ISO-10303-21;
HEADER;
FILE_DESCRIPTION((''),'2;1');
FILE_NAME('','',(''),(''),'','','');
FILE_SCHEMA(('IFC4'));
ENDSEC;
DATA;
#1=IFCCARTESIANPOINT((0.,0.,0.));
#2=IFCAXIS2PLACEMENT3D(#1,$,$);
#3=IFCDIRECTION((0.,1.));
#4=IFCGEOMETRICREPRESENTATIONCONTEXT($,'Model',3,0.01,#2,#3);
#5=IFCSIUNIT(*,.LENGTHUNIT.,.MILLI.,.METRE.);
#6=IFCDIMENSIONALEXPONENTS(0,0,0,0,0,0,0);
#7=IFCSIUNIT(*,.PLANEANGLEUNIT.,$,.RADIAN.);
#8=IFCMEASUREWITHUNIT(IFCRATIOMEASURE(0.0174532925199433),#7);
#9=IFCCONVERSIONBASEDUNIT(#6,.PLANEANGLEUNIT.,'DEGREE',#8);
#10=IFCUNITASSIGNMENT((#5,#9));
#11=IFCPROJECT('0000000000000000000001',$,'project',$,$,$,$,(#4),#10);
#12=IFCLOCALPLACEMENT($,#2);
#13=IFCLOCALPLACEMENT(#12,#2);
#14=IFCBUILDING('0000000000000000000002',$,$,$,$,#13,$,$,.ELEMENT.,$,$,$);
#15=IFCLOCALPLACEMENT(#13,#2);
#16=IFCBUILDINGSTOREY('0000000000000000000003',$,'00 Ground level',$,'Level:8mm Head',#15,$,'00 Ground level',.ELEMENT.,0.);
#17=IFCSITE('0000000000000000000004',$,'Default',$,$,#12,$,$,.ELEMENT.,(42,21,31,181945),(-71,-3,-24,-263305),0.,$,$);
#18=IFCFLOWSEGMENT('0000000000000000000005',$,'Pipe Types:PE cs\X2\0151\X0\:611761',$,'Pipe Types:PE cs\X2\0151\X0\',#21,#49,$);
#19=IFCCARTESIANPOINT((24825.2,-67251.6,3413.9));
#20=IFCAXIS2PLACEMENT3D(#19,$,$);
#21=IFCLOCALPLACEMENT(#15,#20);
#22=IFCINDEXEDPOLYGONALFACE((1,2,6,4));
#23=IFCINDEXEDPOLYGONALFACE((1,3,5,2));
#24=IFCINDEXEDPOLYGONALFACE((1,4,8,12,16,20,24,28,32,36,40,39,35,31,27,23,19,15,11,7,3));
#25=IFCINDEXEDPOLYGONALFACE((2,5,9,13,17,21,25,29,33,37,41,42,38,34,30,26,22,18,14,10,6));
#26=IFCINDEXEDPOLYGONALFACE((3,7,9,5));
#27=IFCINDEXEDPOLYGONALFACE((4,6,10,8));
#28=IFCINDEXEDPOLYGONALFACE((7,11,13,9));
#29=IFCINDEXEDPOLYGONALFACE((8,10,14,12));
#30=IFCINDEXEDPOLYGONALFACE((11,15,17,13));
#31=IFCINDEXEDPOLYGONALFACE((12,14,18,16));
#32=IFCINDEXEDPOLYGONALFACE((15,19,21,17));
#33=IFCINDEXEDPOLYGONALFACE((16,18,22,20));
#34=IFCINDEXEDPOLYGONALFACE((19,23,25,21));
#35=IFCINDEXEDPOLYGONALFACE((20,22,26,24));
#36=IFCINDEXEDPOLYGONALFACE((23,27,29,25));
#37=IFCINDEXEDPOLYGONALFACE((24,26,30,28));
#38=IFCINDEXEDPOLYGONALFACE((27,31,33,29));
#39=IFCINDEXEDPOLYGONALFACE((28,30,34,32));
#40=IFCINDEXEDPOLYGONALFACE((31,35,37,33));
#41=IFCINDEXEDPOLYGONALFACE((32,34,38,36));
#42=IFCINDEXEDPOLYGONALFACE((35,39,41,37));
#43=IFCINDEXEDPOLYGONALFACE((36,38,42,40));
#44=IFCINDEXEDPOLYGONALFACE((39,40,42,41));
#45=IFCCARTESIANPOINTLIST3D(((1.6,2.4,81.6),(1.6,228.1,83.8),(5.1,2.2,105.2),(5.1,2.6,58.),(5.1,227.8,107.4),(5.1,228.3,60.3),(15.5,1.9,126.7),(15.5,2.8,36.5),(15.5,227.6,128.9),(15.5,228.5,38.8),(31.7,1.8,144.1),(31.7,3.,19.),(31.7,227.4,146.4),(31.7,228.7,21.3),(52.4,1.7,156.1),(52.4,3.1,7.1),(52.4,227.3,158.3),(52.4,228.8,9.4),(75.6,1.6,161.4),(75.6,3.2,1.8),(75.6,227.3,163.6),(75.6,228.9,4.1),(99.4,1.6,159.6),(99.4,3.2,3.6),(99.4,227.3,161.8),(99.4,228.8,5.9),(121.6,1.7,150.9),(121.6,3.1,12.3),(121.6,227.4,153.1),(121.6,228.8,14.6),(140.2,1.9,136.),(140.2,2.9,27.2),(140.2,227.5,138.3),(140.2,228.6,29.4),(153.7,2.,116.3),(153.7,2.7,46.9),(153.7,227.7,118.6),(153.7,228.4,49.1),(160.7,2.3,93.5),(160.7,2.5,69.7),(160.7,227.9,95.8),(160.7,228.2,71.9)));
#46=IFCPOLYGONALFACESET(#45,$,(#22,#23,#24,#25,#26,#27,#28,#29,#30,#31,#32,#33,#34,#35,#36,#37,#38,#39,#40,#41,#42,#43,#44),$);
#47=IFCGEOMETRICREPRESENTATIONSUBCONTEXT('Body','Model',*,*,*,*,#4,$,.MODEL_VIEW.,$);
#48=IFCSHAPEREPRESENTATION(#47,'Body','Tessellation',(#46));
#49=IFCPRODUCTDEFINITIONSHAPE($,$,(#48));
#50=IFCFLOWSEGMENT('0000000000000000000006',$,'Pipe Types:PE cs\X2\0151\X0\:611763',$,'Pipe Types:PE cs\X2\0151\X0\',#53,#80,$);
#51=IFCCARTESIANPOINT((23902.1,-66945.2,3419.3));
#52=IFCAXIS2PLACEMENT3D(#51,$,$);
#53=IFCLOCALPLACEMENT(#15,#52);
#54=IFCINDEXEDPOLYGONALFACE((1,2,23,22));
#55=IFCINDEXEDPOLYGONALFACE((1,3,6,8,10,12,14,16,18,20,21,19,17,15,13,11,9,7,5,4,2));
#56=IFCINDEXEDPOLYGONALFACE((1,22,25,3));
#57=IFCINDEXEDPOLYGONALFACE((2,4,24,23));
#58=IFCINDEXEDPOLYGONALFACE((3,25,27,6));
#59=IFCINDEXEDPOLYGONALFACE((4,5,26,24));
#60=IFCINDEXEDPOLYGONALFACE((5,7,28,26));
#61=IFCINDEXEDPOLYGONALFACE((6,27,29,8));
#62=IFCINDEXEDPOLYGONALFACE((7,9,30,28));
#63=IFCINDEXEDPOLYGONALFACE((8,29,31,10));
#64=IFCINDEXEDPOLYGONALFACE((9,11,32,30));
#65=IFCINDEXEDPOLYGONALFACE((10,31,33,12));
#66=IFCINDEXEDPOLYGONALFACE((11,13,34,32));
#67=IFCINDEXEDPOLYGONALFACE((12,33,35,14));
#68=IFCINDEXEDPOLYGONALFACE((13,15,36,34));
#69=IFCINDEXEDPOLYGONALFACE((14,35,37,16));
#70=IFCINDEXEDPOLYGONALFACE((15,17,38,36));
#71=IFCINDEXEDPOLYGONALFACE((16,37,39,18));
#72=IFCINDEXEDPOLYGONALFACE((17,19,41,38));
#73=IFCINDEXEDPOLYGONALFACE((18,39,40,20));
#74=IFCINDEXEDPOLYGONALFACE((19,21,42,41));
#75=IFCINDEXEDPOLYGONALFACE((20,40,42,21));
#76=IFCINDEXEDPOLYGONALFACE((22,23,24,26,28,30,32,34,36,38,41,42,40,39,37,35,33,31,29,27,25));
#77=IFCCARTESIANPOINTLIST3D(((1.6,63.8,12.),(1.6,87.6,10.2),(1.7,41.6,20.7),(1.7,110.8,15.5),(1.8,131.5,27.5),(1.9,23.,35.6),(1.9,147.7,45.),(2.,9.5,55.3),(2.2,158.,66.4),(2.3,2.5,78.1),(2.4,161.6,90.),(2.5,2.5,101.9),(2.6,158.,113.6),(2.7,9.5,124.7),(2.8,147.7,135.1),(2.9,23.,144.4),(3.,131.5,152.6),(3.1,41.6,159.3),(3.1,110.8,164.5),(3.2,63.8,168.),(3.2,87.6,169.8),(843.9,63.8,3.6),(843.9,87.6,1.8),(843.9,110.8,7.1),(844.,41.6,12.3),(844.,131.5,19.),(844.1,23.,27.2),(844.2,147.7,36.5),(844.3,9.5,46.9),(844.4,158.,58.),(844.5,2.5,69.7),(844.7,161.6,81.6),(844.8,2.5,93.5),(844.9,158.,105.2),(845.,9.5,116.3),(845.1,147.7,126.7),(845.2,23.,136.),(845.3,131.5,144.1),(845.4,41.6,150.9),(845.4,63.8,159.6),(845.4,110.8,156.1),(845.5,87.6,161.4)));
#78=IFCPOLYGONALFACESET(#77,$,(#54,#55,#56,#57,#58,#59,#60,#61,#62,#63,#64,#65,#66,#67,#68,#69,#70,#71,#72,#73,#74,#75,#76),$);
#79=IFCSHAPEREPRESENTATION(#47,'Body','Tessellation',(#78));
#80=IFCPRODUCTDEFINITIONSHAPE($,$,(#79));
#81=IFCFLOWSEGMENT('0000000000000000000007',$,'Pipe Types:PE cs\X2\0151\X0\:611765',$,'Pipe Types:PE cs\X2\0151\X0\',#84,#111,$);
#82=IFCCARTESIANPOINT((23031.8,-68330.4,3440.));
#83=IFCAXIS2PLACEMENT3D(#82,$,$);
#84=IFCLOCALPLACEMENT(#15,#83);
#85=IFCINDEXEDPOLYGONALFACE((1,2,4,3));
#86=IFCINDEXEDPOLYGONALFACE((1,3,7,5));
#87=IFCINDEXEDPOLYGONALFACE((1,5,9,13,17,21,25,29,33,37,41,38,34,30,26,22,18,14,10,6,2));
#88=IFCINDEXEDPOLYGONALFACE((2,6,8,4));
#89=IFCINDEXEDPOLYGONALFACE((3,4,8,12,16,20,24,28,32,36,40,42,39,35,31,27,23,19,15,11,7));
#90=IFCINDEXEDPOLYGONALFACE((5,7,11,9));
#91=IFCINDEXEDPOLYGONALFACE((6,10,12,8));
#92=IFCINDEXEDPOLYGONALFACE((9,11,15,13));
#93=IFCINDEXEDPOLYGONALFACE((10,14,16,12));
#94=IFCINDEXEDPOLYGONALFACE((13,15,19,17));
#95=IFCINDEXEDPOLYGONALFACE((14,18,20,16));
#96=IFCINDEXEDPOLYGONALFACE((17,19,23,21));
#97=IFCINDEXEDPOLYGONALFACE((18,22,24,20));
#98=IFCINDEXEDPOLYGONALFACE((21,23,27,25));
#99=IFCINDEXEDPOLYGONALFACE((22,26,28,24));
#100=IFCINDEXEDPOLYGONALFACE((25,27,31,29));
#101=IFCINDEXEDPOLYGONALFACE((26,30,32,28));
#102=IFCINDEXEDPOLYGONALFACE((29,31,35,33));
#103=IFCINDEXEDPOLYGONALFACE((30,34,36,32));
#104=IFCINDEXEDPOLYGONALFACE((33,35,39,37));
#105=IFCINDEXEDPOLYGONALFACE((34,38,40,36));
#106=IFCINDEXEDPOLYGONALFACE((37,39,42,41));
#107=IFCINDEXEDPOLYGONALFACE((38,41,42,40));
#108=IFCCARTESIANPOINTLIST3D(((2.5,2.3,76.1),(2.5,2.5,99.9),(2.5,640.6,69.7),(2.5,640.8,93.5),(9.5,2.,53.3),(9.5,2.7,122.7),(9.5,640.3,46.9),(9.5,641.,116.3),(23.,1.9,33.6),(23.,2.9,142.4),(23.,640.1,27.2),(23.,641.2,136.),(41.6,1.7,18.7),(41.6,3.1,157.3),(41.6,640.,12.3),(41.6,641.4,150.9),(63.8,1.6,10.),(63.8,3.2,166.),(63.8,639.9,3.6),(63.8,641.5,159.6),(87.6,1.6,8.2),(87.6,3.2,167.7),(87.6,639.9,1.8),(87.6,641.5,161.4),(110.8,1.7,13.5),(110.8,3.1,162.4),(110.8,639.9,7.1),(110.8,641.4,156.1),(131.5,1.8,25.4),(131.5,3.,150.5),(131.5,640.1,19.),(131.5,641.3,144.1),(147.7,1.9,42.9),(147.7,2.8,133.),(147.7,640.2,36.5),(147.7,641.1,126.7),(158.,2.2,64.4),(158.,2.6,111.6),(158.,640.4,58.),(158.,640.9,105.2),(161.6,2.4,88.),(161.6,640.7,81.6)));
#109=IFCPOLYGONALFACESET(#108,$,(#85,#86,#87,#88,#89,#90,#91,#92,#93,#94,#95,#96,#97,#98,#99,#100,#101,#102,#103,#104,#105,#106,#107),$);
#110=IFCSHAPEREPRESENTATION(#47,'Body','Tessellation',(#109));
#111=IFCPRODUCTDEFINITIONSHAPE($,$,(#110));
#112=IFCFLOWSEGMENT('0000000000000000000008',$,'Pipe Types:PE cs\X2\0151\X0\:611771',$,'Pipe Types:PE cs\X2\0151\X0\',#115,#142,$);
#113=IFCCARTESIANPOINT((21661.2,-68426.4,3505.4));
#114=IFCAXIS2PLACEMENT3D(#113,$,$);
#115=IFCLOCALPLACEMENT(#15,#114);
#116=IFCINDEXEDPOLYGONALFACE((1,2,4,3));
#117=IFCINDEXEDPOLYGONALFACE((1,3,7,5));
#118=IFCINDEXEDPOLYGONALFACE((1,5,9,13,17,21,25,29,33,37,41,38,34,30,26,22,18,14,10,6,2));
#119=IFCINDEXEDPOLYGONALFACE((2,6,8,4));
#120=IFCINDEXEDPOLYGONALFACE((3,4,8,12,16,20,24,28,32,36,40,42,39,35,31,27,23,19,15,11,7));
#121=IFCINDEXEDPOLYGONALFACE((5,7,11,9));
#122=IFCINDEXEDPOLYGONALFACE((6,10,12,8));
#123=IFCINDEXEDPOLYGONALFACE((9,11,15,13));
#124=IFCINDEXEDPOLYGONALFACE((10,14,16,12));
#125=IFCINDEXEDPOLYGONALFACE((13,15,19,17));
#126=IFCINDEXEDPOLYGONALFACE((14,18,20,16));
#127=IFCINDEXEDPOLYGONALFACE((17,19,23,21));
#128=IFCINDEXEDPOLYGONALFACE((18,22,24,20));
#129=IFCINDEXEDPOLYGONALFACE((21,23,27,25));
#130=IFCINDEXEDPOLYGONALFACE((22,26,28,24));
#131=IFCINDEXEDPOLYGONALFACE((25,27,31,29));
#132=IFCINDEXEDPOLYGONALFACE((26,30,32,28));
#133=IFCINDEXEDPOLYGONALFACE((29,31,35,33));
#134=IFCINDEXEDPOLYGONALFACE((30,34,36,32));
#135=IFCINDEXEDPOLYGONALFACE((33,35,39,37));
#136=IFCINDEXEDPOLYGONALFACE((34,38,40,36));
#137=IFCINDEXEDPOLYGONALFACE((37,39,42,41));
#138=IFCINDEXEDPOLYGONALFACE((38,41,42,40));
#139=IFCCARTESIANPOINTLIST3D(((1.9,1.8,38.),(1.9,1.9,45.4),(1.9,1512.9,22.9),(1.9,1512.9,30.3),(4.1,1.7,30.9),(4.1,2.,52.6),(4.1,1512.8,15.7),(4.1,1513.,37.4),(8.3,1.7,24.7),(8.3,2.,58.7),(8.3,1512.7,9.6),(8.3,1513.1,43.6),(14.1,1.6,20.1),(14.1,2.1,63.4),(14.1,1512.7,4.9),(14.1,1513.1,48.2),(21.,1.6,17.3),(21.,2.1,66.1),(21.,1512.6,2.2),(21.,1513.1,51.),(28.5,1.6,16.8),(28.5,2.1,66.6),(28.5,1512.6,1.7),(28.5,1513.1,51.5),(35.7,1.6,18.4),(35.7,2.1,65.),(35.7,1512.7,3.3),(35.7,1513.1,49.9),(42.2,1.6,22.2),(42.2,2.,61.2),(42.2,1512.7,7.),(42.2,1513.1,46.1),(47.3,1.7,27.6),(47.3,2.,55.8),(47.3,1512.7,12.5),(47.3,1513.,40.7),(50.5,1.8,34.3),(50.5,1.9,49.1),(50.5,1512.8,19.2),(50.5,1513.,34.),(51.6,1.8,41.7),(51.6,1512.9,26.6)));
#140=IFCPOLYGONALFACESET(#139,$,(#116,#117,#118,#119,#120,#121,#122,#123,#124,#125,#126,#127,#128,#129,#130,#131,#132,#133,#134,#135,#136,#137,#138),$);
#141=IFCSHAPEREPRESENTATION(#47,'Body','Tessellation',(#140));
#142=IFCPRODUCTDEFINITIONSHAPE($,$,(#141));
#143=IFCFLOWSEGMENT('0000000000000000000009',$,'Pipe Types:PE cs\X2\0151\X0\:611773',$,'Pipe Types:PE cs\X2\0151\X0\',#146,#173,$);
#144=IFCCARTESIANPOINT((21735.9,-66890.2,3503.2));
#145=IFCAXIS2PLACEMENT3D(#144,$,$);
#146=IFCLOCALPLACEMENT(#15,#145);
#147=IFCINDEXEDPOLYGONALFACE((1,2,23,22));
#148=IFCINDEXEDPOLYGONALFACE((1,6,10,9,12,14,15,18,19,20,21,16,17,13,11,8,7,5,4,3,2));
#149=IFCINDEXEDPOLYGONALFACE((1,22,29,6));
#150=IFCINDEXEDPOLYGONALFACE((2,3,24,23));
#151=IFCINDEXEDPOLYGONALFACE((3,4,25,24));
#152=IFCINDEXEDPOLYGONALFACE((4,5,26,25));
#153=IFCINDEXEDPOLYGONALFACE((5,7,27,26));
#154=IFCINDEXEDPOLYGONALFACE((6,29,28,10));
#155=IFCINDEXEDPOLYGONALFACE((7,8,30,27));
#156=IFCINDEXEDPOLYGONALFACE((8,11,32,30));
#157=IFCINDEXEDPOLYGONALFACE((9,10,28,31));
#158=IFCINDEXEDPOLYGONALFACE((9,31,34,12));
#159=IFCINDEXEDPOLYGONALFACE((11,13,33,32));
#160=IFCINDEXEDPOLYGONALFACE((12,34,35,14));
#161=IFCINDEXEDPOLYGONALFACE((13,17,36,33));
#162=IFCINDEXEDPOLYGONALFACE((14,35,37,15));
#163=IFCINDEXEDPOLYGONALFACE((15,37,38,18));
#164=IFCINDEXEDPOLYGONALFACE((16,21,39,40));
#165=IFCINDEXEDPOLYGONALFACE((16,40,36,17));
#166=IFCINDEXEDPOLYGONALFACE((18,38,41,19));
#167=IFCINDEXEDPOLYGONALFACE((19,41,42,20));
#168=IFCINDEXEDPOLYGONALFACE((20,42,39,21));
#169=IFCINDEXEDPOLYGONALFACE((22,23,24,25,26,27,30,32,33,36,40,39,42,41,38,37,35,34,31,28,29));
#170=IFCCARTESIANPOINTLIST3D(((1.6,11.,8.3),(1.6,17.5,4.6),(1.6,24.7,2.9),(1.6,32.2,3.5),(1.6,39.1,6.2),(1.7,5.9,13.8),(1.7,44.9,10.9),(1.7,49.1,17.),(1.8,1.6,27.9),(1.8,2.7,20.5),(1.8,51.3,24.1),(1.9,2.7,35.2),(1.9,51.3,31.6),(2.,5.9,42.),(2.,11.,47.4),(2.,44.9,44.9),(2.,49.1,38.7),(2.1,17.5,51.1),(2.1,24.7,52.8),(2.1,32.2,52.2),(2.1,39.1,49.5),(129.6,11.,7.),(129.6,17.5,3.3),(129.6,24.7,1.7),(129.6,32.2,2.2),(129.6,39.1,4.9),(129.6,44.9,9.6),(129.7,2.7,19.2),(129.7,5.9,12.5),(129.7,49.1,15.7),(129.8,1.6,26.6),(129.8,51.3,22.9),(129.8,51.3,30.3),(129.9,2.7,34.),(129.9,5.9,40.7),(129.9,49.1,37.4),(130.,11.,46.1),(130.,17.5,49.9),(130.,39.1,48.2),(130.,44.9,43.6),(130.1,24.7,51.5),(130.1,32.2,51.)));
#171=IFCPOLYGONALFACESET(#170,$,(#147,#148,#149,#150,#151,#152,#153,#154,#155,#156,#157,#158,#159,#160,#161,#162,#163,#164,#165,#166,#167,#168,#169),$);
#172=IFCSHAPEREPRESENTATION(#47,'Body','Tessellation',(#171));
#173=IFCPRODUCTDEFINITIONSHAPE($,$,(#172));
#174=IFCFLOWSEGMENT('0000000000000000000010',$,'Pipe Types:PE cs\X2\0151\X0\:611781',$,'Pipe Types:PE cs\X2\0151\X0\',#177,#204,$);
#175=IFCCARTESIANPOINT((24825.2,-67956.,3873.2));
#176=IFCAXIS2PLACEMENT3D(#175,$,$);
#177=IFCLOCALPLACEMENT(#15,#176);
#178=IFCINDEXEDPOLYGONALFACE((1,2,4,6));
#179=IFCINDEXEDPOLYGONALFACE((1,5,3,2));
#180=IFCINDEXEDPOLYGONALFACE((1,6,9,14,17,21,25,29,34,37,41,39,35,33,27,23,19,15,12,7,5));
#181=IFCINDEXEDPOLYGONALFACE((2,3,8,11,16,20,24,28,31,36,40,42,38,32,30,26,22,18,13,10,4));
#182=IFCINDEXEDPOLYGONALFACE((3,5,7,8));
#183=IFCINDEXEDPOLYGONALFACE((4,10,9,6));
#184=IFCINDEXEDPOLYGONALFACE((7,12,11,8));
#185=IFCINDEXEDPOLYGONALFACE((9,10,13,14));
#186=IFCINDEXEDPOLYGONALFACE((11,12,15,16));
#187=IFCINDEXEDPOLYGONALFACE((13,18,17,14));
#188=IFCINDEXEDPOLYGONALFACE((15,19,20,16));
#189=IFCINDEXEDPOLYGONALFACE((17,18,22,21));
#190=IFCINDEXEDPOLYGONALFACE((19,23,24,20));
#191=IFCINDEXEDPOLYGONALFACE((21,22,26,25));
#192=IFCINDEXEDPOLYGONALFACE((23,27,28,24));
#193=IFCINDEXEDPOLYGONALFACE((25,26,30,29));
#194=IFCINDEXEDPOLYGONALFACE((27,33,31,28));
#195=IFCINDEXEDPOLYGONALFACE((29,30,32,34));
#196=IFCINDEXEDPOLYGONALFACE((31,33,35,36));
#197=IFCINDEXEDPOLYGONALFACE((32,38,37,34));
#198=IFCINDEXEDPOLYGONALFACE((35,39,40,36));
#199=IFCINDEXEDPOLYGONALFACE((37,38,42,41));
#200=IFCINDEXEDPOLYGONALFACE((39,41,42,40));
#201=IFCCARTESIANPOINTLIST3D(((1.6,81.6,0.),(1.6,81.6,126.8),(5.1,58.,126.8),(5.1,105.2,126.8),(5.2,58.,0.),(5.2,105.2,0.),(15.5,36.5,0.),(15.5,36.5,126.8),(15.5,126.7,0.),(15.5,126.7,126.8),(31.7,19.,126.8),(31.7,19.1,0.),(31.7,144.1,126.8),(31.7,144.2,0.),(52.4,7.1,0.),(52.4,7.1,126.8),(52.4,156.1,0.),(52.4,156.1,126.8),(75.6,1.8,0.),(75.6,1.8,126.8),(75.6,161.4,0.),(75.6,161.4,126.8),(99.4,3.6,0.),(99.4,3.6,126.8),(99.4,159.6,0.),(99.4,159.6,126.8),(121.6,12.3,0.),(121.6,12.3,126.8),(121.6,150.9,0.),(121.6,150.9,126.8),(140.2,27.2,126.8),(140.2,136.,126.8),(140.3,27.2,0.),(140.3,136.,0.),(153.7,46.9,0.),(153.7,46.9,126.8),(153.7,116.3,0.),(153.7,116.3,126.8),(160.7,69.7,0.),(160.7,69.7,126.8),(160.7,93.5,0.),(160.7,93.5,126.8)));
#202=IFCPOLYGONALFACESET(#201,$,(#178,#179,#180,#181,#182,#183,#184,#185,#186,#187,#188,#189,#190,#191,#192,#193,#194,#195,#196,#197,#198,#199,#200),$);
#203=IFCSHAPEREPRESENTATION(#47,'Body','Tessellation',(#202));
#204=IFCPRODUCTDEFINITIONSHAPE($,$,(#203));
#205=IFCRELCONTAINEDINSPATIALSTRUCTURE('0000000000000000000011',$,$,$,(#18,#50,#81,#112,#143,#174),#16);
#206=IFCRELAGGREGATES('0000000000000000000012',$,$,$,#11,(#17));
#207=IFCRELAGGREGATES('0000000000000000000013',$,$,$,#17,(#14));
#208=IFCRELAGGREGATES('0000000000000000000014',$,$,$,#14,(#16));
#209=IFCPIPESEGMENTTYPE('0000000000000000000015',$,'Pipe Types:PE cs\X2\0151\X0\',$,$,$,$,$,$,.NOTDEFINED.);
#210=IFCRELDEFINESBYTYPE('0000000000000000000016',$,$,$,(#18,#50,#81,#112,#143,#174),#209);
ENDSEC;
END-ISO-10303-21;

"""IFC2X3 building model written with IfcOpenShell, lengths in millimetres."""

from ifc_helpers import new_model, entity, si_unit, converted_unit, direction, frame, frame_2d, origin, origin_2d_with_axis, place, context, subcontext, project, spatial, circle, extrude, type_object, element, save


model = new_model("IFC2X3")

# Units and contexts
model_context = context("Model", 3, precision=0.01, world=origin(), true_north=direction((0.0, 1.0)))
body_context = subcontext(model_context, "Body", "Model", "MODEL_VIEW")
ifc_project = project(units=[si_unit("LENGTHUNIT", "METRE", prefix="MILLI"), converted_unit("PLANEANGLEUNIT", "DEGREE", entity("IfcRatioMeasure", 0.0174532925199433), si_unit("PLANEANGLEUNIT", "RADIAN"), dimensions=[0, 0, 0, 0, 0, 0, 0])], contexts=[model_context])

# Site, building, storey
site_placement = place(None, origin())
site = spatial("IfcSite", under=ifc_project, at=site_placement, Name="Default", CompositionType="ELEMENT", RefLatitude=(42, 21, 31, 181945), RefLongitude=(-71, -3, -24, -263305), RefElevation=0.0)
building_placement = place(site_placement, origin())
building = spatial("IfcBuilding", under=site, at=building_placement, CompositionType="ELEMENT")
storey_placement = place(building_placement, origin())
storey = spatial("IfcBuildingStorey", under=building, at=storey_placement, Name="00 Ground level", ObjectType="Level:8mm Head", LongName="00 Ground level", CompositionType="ELEMENT", Elevation=0.0)

# Flow segments
pipe_segment_type = type_object("IfcPipeSegmentType", Name="Pipe Types:PE cső", PredefinedType="NOTDEFINED")
flow_segment_1_placement = place(storey_placement, frame((24825.2, -67251.6, 3413.9)))
element("IfcFlowSegment", 1, at=flow_segment_1_placement, inside=storey, type_object=pipe_segment_type, Name="Pipe Types:PE cső:611761", ObjectType="Pipe Types:PE cső", context=body_context, shape_type="SweptSolid", body=[
    extrude(circle(Radius=80.0, at=origin_2d_with_axis()), frame((81.6, 2.4, 81.6), z_axis=(0.0, 0.99995, 0.01), x_axis=(-1.0, 0.0, 0.0)), (0.0, 0.0, 1.0), 225.7),
])
flow_segment_2_placement = place(storey_placement, frame((23902.1, -66945.2, 3419.3)))
element("IfcFlowSegment", 2, at=flow_segment_2_placement, inside=storey, type_object=pipe_segment_type, Name="Pipe Types:PE cső:611763", ObjectType="Pipe Types:PE cső", context=body_context, shape_type="SweptSolid", body=[
    extrude(circle(Radius=80.0, at=frame_2d((0.0, 0.0), x_axis=(1.0, 0.0))), frame((2.4, 81.6, 90.0), z_axis=(0.99995, 0.0, -0.01), x_axis=(0.0, 1.0, 0.0)), (0.0, 0.0, 1.0), 842.3),
])
flow_segment_3_placement = place(storey_placement, frame((23031.8, -68330.4, 3440.0)))
element("IfcFlowSegment", 3, at=flow_segment_3_placement, inside=storey, type_object=pipe_segment_type, Name="Pipe Types:PE cső:611765", ObjectType="Pipe Types:PE cső", context=body_context, shape_type="SweptSolid", body=[
    extrude(circle(Radius=80.0, at=frame_2d((0.0, 0.0), x_axis=(1.0, 0.0))), frame((81.6, 2.4, 88.0), z_axis=(0.0, 0.99995, -0.01), x_axis=(1.0, 0.0, 0.0)), (0.0, 0.0, 1.0), 638.3),
])
flow_segment_4_placement = place(storey_placement, frame((21661.2, -68426.4, 3505.4)))
element("IfcFlowSegment", 4, at=flow_segment_4_placement, inside=storey, type_object=pipe_segment_type, Name="Pipe Types:PE cső:611771", ObjectType="Pipe Types:PE cső", context=body_context, shape_type="SweptSolid", body=[
    extrude(circle(Radius=25.0, at=frame_2d((0.0, 0.0), x_axis=(1.0, 0.0))), frame((26.6, 1512.9, 26.6), z_axis=(0.0, -0.99995, 0.01), x_axis=(1.0, 0.0, 0.0)), (0.0, 0.0, 1.0), 1511.1),
])
flow_segment_5_placement = place(storey_placement, frame((21735.9, -66890.2, 3503.2)))
element("IfcFlowSegment", 5, at=flow_segment_5_placement, inside=storey, type_object=pipe_segment_type, Name="Pipe Types:PE cső:611773", ObjectType="Pipe Types:PE cső", context=body_context, shape_type="SweptSolid", body=[
    extrude(circle(Radius=25.0, at=frame_2d((0.0, 0.0), x_axis=(1.0, 0.0))), frame((129.8, 26.6, 26.6), z_axis=(-0.99995, 0.0, 0.01), x_axis=(0.0, -1.0, 0.0)), (0.0, 0.0, 1.0), 128.0),
])
flow_segment_6_placement = place(storey_placement, frame((24825.2, -67956.0, 3873.2)))
element("IfcFlowSegment", 6, at=flow_segment_6_placement, inside=storey, type_object=pipe_segment_type, Name="Pipe Types:PE cső:611781", ObjectType="Pipe Types:PE cső", context=body_context, shape_type="SweptSolid", body=[
    extrude(circle(Radius=80.0, at=origin_2d_with_axis()), frame((81.6, 81.6, 0.0), z_axis=(-0.000102, -0.00007, 1.0), x_axis=(-1.0, 0.0, -0.000102)), (0.0, 0.0, 1.0), 126.8),
])

save(model, "model.ifc")
